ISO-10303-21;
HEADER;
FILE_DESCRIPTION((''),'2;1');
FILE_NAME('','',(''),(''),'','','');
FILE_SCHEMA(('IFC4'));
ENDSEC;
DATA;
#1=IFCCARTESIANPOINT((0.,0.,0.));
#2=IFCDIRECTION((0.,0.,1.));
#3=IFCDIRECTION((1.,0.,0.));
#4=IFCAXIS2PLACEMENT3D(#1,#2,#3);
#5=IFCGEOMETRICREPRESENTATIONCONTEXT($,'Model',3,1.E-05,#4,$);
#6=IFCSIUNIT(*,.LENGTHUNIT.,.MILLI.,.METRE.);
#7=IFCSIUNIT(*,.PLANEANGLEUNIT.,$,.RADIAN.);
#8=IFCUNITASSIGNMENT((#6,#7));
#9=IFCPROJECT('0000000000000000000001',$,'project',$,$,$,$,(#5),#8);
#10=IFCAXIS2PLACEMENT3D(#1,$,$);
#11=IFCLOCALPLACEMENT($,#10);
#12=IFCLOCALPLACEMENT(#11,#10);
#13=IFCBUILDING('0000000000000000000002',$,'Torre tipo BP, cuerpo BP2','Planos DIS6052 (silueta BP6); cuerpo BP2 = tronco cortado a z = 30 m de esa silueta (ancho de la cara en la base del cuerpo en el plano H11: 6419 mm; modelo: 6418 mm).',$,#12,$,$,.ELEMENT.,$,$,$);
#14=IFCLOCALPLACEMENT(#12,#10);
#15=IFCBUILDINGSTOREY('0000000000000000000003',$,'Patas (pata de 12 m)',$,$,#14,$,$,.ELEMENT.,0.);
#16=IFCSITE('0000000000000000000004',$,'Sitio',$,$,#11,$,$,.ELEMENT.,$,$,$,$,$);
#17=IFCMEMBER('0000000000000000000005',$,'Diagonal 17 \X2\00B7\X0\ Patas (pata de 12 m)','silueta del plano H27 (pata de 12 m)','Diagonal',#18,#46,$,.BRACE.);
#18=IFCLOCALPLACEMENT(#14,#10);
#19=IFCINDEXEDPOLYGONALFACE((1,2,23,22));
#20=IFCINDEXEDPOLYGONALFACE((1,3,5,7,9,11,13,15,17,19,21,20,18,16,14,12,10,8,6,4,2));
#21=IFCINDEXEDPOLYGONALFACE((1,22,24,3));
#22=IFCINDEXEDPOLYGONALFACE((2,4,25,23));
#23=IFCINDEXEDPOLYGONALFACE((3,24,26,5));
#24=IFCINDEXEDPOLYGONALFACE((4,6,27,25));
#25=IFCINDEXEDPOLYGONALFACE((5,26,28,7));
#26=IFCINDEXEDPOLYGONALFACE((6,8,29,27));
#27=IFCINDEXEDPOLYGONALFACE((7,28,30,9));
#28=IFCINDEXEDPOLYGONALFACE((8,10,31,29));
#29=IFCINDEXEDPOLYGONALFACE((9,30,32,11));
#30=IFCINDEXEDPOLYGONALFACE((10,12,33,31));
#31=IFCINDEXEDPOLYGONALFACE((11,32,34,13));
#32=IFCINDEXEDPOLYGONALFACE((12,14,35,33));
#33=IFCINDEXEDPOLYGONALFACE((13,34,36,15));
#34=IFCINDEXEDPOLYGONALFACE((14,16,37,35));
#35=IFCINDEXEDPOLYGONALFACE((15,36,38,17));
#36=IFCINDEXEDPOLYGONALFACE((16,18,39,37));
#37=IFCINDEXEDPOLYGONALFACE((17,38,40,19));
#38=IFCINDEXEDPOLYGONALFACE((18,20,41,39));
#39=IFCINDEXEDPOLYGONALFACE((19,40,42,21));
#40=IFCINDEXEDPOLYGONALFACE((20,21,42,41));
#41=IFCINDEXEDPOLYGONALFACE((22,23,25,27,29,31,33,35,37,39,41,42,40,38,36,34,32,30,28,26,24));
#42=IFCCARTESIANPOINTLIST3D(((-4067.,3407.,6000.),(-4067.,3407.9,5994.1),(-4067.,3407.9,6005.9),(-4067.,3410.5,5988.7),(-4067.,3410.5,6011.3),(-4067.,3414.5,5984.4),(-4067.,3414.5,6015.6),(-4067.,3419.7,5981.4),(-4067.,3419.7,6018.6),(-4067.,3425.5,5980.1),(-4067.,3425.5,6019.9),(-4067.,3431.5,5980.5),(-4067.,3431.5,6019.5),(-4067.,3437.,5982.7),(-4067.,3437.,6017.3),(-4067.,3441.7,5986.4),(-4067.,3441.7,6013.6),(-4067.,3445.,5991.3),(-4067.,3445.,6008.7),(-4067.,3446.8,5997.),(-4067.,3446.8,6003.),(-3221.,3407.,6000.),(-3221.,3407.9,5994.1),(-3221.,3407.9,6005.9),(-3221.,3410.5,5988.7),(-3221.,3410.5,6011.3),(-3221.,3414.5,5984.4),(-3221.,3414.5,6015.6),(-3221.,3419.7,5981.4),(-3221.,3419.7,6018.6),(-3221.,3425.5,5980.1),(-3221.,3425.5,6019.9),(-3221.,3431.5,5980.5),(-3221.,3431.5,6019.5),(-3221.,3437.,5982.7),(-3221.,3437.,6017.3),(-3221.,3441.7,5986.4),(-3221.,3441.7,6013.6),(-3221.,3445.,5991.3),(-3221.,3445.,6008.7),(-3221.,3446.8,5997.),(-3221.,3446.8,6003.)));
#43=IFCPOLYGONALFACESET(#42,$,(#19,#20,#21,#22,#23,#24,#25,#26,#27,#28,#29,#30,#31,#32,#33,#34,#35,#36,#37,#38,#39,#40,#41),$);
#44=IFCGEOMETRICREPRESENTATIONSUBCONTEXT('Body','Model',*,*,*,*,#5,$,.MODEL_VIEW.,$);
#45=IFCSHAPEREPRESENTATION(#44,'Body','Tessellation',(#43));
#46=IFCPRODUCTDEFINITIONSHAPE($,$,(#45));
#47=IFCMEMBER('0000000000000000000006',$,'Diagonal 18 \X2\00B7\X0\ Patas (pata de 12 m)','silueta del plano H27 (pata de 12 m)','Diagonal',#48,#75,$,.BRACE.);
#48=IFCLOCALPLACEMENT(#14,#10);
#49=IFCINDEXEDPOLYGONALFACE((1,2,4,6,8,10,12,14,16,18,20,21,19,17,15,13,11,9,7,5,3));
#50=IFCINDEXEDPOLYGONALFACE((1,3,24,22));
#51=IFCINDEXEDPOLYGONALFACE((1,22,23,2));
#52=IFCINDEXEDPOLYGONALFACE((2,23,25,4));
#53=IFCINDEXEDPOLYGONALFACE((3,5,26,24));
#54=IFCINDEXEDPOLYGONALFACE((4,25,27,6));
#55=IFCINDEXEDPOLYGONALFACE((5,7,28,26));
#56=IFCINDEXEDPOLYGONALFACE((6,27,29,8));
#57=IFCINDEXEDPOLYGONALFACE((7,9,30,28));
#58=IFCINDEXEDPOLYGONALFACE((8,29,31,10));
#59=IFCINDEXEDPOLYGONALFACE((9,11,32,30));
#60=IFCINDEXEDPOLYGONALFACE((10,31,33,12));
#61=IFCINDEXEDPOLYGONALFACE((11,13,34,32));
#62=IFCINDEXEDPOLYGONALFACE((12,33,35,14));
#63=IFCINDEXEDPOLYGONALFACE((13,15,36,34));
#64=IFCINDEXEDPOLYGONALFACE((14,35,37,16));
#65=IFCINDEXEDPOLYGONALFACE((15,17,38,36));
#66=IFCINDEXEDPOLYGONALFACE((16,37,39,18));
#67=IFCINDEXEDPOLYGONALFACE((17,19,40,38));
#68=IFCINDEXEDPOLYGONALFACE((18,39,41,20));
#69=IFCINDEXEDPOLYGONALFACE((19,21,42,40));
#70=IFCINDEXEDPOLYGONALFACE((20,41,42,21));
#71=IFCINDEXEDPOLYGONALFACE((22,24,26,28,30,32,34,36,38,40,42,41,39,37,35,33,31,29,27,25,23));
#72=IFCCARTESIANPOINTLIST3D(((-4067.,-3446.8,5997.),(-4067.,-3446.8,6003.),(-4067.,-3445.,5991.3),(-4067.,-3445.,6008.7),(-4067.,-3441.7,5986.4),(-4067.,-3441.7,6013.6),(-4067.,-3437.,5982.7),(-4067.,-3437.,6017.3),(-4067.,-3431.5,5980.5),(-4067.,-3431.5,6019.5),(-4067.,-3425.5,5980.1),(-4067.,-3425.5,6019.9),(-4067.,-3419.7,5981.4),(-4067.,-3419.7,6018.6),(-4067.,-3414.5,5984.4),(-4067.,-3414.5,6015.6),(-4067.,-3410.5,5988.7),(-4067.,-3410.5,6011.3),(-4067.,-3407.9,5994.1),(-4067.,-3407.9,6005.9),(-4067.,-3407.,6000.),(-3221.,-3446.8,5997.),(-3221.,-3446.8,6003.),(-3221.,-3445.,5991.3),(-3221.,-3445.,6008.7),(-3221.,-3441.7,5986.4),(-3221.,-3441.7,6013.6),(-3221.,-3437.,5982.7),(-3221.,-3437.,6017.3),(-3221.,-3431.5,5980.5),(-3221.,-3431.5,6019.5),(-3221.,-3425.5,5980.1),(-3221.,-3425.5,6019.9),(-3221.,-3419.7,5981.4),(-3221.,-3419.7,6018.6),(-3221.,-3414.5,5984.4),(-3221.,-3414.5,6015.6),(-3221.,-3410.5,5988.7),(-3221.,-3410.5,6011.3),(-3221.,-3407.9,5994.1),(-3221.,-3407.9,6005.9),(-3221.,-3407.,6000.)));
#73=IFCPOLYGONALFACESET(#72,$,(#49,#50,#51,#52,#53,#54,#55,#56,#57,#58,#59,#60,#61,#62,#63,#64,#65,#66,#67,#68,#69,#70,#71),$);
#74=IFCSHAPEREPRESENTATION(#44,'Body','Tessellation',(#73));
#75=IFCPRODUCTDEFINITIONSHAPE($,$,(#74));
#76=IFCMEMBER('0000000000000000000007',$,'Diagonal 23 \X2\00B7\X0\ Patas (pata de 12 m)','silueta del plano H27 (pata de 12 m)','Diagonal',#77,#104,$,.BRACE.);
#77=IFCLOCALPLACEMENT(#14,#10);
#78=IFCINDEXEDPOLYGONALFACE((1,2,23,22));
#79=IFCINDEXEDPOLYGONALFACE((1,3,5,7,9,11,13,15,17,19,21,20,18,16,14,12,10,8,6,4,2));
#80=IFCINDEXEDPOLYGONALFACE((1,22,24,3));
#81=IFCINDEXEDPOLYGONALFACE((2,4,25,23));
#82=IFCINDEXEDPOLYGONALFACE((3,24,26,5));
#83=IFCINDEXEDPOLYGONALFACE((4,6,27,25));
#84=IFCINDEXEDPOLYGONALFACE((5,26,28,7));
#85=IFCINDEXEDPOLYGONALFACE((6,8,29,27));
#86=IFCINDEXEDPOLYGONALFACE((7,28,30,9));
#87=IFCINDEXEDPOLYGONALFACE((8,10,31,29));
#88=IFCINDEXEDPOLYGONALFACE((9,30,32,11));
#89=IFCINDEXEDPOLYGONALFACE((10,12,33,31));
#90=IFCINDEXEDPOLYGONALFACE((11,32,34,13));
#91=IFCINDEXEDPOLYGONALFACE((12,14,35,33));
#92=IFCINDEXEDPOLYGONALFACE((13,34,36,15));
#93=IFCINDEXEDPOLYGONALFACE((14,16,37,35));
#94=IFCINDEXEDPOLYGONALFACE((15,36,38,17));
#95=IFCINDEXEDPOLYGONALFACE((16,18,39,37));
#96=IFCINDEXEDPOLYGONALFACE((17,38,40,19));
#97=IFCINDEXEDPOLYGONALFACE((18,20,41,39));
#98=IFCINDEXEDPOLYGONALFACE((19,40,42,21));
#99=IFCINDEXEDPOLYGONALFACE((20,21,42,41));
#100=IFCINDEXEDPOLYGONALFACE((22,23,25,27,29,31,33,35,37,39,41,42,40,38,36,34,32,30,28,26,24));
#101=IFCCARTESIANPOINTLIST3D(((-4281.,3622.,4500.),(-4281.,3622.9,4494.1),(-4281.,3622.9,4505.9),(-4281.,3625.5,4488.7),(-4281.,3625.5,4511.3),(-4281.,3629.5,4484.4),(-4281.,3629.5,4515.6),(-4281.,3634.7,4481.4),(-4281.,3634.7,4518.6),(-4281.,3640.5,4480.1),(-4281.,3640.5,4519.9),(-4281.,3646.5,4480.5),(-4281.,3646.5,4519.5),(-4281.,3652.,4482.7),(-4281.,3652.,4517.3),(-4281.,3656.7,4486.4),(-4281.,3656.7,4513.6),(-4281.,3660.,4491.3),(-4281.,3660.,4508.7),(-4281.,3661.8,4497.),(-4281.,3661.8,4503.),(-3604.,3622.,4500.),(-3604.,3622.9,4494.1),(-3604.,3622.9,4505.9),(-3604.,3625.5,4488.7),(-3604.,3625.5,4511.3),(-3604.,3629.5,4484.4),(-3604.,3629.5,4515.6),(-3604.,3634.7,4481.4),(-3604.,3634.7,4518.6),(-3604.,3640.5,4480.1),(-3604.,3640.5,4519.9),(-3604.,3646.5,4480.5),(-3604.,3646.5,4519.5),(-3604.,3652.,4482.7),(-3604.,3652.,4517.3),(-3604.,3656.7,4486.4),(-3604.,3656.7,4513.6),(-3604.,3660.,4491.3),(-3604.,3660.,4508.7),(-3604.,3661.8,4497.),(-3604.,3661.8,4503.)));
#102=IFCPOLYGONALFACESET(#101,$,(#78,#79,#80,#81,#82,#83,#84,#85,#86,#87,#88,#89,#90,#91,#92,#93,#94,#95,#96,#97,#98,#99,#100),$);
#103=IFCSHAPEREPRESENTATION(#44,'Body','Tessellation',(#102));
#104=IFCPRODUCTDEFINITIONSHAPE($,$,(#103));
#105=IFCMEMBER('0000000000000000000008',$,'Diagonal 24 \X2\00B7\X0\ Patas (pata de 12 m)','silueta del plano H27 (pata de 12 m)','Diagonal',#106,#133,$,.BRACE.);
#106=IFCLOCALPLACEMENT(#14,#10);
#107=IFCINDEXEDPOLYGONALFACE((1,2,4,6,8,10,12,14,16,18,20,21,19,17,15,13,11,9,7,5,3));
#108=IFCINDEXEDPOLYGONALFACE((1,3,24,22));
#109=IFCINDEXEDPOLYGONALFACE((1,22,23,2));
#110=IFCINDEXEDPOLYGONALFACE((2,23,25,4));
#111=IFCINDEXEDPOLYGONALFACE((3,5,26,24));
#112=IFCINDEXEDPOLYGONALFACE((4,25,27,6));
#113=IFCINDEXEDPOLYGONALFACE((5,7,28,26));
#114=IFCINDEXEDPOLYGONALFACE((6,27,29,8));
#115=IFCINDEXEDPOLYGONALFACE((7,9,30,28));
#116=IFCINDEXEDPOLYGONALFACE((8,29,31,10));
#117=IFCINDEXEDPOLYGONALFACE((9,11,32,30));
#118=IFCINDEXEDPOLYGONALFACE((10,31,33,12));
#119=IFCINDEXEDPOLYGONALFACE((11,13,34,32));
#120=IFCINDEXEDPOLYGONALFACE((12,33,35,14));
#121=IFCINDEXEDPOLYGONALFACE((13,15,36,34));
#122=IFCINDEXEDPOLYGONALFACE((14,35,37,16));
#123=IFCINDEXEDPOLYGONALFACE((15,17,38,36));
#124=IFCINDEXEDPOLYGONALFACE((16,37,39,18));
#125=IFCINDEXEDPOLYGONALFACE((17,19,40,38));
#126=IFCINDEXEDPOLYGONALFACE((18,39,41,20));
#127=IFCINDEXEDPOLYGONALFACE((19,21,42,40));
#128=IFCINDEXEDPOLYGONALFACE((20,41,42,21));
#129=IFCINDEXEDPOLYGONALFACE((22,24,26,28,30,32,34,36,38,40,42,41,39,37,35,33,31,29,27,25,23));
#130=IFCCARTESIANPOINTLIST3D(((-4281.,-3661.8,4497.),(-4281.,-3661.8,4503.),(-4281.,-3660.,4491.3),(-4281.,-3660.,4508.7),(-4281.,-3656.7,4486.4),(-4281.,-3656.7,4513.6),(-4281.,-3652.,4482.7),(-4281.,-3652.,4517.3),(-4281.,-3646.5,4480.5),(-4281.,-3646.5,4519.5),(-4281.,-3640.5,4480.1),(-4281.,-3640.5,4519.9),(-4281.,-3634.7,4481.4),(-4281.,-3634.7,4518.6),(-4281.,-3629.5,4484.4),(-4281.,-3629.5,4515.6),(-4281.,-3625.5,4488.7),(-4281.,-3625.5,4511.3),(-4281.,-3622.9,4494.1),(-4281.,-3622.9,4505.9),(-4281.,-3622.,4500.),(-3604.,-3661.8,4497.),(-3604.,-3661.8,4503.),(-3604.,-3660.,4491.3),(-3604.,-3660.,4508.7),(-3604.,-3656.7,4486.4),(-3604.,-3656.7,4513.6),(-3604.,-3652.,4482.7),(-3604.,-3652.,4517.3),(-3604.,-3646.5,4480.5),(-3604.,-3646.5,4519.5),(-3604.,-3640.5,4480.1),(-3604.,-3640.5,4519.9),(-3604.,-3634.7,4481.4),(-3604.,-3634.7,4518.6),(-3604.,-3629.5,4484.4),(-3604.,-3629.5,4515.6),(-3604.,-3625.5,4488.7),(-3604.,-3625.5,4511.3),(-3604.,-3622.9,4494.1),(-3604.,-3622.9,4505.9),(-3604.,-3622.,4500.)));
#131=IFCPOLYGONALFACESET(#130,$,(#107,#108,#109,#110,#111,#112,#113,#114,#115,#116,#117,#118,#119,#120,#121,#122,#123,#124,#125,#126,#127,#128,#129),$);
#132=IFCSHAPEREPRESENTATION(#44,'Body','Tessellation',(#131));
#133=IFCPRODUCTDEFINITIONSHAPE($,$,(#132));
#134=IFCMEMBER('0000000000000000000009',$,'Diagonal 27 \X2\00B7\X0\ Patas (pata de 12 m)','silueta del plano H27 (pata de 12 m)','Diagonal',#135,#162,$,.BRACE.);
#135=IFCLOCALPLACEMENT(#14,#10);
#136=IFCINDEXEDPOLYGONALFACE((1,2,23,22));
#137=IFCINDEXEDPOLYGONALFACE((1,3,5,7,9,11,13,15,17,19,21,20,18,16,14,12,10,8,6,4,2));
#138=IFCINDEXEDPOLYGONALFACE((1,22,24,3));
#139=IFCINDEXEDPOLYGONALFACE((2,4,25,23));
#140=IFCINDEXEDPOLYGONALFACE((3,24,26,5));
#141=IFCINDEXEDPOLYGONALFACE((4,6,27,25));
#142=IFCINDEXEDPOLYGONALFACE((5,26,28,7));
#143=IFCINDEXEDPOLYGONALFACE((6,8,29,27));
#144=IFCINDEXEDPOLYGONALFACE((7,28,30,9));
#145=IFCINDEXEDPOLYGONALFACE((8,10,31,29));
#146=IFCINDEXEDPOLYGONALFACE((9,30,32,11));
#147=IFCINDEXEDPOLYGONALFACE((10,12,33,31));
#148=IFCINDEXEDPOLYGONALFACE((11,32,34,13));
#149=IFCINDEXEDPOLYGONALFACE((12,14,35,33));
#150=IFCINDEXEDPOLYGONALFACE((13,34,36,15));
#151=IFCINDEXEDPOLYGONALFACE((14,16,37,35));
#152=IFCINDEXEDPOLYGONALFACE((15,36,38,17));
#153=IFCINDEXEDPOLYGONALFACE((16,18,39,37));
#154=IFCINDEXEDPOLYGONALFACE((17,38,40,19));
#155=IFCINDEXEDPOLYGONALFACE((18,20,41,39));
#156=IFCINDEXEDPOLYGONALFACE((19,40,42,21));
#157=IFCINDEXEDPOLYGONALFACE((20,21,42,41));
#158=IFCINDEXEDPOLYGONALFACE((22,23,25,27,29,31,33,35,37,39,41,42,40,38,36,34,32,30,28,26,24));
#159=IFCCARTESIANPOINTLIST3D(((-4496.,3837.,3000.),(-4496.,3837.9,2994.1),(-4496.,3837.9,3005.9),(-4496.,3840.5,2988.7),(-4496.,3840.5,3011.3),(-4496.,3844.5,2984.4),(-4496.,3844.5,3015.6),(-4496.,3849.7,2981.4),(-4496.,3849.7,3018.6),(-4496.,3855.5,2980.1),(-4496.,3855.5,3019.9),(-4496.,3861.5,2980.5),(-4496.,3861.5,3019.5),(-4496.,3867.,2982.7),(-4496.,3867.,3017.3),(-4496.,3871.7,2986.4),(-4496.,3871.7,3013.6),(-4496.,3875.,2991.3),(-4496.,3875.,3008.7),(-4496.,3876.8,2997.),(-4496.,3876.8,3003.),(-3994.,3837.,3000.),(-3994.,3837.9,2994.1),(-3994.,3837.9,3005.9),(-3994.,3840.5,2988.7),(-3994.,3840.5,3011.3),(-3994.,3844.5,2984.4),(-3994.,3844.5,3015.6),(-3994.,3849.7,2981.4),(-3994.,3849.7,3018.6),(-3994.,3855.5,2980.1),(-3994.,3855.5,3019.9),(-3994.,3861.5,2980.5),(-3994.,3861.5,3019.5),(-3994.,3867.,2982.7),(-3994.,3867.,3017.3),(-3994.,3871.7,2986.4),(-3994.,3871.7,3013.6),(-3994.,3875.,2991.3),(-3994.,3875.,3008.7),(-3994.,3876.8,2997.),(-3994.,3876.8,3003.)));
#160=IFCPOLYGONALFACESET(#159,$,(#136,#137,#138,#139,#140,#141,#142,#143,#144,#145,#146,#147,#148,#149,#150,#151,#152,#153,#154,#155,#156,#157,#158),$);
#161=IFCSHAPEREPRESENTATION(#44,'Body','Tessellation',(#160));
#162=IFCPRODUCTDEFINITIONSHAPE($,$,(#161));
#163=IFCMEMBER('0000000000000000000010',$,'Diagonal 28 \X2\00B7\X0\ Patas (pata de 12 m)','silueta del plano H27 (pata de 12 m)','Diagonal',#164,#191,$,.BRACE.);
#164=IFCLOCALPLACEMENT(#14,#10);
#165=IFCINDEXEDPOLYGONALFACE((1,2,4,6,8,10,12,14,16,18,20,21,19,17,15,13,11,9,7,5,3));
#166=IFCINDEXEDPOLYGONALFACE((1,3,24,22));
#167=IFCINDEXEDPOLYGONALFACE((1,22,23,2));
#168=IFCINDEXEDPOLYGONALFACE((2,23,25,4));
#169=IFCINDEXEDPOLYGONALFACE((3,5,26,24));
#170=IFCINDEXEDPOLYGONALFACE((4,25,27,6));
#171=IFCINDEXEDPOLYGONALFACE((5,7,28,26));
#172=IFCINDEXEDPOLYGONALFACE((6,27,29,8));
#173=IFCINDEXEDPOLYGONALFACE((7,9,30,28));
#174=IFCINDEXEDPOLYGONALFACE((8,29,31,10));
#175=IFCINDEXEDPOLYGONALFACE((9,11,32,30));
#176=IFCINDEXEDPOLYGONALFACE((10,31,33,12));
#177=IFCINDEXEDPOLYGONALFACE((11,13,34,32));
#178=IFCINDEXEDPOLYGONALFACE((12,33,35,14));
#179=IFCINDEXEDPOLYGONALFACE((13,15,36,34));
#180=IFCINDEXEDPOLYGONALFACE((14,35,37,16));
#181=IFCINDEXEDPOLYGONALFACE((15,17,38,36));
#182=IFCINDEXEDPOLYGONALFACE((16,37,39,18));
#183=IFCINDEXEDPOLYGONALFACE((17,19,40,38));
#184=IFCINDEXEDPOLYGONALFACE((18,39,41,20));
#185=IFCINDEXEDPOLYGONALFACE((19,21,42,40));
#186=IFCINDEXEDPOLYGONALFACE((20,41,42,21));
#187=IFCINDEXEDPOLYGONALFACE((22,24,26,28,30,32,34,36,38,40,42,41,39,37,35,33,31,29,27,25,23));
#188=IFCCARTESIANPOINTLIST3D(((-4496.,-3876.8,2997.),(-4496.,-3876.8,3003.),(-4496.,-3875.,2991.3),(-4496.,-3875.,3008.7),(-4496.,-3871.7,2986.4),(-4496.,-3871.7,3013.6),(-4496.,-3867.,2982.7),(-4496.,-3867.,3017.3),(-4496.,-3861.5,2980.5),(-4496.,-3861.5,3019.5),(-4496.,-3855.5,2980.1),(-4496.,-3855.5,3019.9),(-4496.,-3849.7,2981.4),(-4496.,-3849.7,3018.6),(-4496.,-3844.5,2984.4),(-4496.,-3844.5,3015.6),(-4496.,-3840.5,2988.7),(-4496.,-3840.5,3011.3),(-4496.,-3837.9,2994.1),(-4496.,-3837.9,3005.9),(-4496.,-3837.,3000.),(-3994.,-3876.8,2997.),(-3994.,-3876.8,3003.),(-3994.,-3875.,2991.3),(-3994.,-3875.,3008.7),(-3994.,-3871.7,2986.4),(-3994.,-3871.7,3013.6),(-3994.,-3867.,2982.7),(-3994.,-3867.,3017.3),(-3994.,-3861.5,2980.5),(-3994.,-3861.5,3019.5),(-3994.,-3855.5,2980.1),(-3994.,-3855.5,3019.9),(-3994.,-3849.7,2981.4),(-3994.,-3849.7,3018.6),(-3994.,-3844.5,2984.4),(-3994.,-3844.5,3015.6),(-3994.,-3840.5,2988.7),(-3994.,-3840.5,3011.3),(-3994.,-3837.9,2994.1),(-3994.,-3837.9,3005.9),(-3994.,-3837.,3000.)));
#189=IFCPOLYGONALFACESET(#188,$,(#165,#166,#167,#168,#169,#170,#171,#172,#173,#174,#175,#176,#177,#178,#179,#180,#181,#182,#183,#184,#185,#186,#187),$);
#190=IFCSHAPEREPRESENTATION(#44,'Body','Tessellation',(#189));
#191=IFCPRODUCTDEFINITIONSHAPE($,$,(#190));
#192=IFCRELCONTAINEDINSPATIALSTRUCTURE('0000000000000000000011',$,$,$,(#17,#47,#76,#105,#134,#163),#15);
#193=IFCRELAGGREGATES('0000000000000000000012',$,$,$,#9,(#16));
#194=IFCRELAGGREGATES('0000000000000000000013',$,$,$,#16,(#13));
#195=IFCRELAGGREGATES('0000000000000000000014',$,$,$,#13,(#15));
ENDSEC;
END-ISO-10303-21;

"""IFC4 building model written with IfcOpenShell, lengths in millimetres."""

from ifc_helpers import new_model, si_unit, frame, origin, origin_with_axes, place, context, subcontext, project, spatial, circle, extrude, element, save


model = new_model("IFC4")

# Units and contexts
model_context = context("Model", 3, precision=1e-05, world=origin_with_axes())
body_context = subcontext(model_context, "Body", "Model", "MODEL_VIEW")
ifc_project = project(units=[si_unit("LENGTHUNIT", "METRE", prefix="MILLI"), si_unit("PLANEANGLEUNIT", "RADIAN")], contexts=[model_context])

# Site, building, storey
site_placement = place(None, origin())
site = spatial("IfcSite", under=ifc_project, at=site_placement, Name="Sitio", CompositionType="ELEMENT")
building_placement = place(site_placement, origin())
building = spatial("IfcBuilding", under=site, at=building_placement, Name="Torre tipo BP, cuerpo BP2", Description="Planos DIS6052 (silueta BP6); cuerpo BP2 = tronco cortado a z = 30 m de esa silueta (ancho de la cara en la base del cuerpo en el plano H11: 6419 mm; modelo: 6418 mm).", CompositionType="ELEMENT")
storey_placement = place(building_placement, origin())
storey = spatial("IfcBuildingStorey", under=building, at=storey_placement, Name="Patas (pata de 12 m)", CompositionType="ELEMENT", Elevation=0.0)

# Members
for number, where, z_axis, x_axis, name in (
    (1, (-4067.0, 3427.0, 6000.0), (1.0, 0.0, 0.0), (0.0, -1.0, 0.0), "Diagonal 17 · Patas (pata de 12 m)"),
    (2, (-4067.0, -3427.0, 6000.0), (1.0, 0.0, 0.0), (0.0, 1.0, 0.0), "Diagonal 18 · Patas (pata de 12 m)"),
):
    element("IfcMember", number, at=place(storey_placement, frame(where, z_axis=z_axis, x_axis=x_axis)), inside=storey, Name=name, Description="silueta del plano H27 (pata de 12 m)", ObjectType="Diagonal", PredefinedType="BRACE", context=body_context, shape_type="SweptSolid", body=[
        extrude(circle(Radius=20.0), None, (0.0, 0.0, 1.0), 846.0),
    ])
for number, where, z_axis, x_axis, name in (
    (3, (-4281.0, 3642.0, 4500.0), (1.0, 0.0, 0.0), (0.0, -1.0, 0.0), "Diagonal 23 · Patas (pata de 12 m)"),
    (4, (-4281.0, -3642.0, 4500.0), (1.0, 0.0, 0.0), (0.0, 1.0, 0.0), "Diagonal 24 · Patas (pata de 12 m)"),
):
    element("IfcMember", number, at=place(storey_placement, frame(where, z_axis=z_axis, x_axis=x_axis)), inside=storey, Name=name, Description="silueta del plano H27 (pata de 12 m)", ObjectType="Diagonal", PredefinedType="BRACE", context=body_context, shape_type="SweptSolid", body=[
        extrude(circle(Radius=20.0), None, (0.0, 0.0, 1.0), 677.0),
    ])
for number, where, z_axis, x_axis, name in (
    (5, (-4496.0, 3857.0, 3000.0), (1.0, 0.0, 0.0), (0.0, -1.0, 0.0), "Diagonal 27 · Patas (pata de 12 m)"),
    (6, (-4496.0, -3857.0, 3000.0), (1.0, 0.0, 0.0), (0.0, 1.0, 0.0), "Diagonal 28 · Patas (pata de 12 m)"),
):
    element("IfcMember", number, at=place(storey_placement, frame(where, z_axis=z_axis, x_axis=x_axis)), inside=storey, Name=name, Description="silueta del plano H27 (pata de 12 m)", ObjectType="Diagonal", PredefinedType="BRACE", context=body_context, shape_type="SweptSolid", body=[
        extrude(circle(Radius=20.0), None, (0.0, 0.0, 1.0), 502.0),
    ])

save(model, "model.ifc")
